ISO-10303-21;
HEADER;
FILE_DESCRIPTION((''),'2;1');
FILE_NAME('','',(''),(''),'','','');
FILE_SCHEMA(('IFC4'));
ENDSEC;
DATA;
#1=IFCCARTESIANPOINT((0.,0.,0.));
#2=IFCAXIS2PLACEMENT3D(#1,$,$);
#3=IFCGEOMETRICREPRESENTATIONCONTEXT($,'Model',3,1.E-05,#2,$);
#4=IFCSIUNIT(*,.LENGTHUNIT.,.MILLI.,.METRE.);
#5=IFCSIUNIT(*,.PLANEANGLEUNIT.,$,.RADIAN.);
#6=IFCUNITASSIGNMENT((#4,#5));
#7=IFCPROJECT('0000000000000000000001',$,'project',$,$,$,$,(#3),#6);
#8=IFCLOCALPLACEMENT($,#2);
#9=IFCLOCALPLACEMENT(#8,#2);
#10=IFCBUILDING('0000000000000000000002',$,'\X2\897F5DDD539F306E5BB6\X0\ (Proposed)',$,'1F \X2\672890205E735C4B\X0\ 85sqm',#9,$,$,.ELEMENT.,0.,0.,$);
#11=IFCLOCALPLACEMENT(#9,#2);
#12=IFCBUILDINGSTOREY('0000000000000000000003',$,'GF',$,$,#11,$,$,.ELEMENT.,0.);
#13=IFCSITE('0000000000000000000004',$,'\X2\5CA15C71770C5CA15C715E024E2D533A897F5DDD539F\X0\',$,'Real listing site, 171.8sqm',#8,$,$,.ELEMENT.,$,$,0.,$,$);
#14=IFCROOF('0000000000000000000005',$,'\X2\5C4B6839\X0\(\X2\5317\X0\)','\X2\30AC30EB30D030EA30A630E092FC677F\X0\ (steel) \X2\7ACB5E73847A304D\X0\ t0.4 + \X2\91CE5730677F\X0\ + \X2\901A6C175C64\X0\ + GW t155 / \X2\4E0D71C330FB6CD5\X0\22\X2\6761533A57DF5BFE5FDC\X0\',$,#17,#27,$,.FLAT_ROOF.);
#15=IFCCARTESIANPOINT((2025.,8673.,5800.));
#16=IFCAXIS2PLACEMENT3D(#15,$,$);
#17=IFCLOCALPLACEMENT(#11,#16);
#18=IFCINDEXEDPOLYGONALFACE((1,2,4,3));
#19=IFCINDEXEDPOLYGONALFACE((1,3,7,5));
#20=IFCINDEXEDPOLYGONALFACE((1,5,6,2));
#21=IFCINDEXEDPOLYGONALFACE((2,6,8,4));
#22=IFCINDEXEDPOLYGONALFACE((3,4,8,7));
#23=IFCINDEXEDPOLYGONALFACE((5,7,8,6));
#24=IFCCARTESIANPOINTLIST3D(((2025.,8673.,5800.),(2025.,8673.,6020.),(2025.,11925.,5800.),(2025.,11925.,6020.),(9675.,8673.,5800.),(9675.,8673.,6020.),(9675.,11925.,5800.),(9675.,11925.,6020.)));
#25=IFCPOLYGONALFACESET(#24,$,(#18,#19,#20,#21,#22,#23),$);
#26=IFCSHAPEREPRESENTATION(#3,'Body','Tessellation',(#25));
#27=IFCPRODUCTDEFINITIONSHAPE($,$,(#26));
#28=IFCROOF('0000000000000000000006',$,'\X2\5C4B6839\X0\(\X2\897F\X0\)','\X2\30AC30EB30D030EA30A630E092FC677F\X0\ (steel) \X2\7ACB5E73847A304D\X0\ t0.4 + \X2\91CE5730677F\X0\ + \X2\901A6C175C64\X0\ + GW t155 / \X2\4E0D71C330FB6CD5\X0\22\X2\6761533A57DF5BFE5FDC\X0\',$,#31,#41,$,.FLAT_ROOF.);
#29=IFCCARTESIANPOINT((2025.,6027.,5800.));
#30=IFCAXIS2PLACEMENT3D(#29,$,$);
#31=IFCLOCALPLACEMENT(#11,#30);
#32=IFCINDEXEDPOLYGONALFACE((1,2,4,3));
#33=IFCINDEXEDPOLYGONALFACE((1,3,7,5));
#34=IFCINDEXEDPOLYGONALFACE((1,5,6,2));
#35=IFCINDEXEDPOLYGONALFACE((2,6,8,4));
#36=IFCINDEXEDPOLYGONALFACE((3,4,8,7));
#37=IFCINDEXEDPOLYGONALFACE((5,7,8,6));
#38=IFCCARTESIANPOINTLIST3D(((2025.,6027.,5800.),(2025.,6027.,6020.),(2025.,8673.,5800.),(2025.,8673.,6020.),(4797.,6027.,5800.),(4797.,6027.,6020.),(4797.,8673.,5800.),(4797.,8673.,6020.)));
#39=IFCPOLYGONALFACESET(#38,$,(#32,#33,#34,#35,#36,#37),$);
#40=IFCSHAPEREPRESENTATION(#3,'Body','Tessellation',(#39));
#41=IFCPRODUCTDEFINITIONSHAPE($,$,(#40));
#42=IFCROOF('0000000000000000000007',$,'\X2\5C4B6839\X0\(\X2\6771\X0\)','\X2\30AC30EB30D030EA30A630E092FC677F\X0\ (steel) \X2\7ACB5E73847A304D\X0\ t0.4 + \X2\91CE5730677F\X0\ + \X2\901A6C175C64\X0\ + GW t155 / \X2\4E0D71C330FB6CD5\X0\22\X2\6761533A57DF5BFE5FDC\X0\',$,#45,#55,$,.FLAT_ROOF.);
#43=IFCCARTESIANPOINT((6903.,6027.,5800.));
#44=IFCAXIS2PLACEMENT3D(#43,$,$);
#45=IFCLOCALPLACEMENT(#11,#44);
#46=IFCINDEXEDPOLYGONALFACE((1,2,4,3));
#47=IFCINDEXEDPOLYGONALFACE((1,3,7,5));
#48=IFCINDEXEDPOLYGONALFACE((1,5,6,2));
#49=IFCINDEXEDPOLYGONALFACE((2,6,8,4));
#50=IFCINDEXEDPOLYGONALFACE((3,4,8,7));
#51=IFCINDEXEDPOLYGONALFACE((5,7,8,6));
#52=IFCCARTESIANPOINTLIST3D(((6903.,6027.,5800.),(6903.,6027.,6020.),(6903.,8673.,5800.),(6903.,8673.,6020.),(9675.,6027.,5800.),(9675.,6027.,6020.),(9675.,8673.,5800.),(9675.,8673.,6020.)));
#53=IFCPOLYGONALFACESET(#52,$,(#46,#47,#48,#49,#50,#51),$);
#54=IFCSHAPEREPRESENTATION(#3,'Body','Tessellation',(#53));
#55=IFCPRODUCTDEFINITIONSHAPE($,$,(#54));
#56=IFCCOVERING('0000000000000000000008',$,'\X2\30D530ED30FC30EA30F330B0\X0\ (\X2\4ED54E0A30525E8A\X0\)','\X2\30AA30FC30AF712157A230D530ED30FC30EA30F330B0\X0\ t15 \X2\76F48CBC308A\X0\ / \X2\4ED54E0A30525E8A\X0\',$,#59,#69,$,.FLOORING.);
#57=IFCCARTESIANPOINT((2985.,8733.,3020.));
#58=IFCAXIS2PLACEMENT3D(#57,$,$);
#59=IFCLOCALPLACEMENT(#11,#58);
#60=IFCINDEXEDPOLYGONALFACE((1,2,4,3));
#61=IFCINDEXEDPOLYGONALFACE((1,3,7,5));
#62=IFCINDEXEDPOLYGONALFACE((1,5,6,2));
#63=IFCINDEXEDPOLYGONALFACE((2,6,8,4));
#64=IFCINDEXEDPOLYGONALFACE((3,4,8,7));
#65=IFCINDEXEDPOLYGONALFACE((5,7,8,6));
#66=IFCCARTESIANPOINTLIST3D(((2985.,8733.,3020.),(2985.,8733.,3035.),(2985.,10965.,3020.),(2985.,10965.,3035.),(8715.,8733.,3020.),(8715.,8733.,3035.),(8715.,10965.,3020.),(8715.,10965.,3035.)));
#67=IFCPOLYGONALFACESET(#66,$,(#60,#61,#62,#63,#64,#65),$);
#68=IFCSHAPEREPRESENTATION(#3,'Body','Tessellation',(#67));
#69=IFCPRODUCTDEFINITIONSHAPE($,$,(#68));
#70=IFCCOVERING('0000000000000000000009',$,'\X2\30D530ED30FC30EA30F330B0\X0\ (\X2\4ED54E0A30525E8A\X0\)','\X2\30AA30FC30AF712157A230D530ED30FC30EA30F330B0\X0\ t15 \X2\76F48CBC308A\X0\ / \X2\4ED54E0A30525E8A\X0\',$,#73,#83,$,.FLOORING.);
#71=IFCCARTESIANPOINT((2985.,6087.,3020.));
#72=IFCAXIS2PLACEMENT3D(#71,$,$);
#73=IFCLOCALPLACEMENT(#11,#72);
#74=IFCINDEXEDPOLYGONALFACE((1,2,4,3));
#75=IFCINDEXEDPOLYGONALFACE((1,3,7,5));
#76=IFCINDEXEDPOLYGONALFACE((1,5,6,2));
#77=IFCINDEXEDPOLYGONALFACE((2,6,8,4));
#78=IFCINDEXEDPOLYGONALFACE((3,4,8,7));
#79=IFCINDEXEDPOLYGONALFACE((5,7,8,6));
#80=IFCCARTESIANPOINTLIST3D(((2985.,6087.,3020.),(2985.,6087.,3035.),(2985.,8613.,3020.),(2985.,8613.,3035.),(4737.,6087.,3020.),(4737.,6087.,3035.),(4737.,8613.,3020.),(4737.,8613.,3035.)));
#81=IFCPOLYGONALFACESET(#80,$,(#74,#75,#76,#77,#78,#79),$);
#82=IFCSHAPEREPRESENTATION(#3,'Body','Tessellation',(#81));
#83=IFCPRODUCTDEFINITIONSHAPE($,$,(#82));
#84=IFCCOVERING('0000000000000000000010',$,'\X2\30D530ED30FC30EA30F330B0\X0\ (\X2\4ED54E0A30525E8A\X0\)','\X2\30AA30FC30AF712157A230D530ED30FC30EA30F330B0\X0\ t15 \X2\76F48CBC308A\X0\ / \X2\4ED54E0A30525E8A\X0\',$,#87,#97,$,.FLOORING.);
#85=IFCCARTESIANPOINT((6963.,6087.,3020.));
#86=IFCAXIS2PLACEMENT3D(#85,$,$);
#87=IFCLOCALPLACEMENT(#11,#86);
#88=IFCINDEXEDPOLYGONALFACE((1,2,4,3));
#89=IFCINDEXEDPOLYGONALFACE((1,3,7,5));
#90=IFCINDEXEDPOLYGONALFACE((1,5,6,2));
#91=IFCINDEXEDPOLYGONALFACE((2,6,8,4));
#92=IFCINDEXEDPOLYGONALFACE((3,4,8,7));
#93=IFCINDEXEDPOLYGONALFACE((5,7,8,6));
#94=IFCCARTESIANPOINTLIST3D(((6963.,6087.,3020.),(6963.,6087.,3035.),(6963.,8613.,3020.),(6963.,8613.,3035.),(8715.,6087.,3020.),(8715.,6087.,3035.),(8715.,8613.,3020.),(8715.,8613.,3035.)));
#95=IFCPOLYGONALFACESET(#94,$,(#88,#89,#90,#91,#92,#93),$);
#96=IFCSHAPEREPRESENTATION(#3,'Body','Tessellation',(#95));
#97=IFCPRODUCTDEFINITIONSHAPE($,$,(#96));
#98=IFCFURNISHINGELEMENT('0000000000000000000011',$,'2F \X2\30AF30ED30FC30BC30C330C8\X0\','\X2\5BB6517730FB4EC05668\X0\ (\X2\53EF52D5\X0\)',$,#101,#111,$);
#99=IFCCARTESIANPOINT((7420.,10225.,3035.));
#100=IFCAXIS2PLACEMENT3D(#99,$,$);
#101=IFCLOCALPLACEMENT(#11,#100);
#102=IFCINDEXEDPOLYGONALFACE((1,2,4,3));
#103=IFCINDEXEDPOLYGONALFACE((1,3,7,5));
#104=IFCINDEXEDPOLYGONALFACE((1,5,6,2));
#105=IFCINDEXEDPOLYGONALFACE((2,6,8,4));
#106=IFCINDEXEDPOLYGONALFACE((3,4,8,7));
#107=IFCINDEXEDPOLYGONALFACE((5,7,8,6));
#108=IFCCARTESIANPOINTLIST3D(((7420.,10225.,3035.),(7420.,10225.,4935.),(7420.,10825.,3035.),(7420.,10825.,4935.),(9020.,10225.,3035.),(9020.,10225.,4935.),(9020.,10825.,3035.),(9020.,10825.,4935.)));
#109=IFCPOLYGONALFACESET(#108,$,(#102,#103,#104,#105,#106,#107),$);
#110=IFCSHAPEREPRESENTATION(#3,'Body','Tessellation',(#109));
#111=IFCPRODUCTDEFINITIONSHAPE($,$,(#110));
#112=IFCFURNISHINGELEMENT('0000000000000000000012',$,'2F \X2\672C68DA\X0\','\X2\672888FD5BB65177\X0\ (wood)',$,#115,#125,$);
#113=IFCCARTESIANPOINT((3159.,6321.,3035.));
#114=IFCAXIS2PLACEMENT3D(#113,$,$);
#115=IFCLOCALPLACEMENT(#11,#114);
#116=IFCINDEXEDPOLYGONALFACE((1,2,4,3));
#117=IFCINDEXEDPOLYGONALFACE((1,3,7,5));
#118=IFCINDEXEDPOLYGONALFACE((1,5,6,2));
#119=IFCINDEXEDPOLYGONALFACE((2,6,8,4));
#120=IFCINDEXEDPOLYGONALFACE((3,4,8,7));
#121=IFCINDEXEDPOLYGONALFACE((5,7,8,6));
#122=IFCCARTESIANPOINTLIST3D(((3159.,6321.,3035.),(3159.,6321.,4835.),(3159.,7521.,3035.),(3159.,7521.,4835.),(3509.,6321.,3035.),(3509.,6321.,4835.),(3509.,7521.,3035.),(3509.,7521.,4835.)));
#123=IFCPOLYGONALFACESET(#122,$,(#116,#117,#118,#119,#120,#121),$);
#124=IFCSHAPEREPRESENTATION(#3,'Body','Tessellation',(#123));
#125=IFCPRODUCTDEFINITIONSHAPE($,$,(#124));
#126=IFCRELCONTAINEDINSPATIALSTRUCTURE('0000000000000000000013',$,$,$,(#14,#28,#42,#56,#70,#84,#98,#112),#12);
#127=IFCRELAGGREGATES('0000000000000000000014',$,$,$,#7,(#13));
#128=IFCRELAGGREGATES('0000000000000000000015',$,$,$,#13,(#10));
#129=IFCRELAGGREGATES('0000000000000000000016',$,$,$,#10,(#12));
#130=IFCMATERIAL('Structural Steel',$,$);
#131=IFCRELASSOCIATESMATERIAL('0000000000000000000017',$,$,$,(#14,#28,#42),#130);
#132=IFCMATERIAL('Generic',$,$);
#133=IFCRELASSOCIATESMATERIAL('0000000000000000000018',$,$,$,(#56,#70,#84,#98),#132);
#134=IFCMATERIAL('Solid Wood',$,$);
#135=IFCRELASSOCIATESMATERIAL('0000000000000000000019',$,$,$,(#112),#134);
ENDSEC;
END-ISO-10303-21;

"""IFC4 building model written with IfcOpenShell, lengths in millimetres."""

from ifc_helpers import new_model, si_unit, frame, frame_2d, origin, place, context, project, spatial, rectangle, extrude, material, element, save


model = new_model("IFC4")

# Units and contexts
model_context = context("Model", 3, precision=1e-05, world=origin())
ifc_project = project(units=[si_unit("LENGTHUNIT", "METRE", prefix="MILLI"), si_unit("PLANEANGLEUNIT", "RADIAN")], contexts=[model_context])

# Site, building, storey
site_placement = place(None, origin())
site = spatial("IfcSite", under=ifc_project, at=site_placement, Name="岡山県岡山市中区西川原", ObjectType="Real listing site, 171.8sqm", CompositionType="ELEMENT", RefElevation=0.0)
building_placement = place(site_placement, origin())
building = spatial("IfcBuilding", under=site, at=building_placement, Name="西川原の家 (Proposed)", ObjectType="1F 木造平屋 85sqm", CompositionType="ELEMENT", ElevationOfRefHeight=0.0, ElevationOfTerrain=0.0)
storey_placement = place(building_placement, origin())
storey = spatial("IfcBuildingStorey", under=building, at=storey_placement, Name="GF", CompositionType="ELEMENT", Elevation=0.0)

# Shared definitions
ifc_material_1 = material(Name="Solid Wood")

# Roofs
ifc_material_2 = material(Name="Structural Steel")
for number, where, name in (
    (1, (2025.0, 8673.0, 5800.0), "屋根(北)"),
):
    element("IfcRoof", number, at=place(storey_placement, frame(where)), inside=storey, material=ifc_material_2, Name=name, Description="ガルバリウム鋼板 (steel) 立平葺き t0.4 + 野地板 + 通気層 + GW t155 / 不燃・法22条区域対応", PredefinedType="FLAT_ROOF", context=model_context, shape_type="SweptSolid", body=[
        extrude(rectangle(XDim=7650.0, YDim=3252.0, at=frame_2d((3825.0, 1626.0))), frame((2025.0, 8673.0, 5800.0)), (0.0, 0.0, 1.0), 220.0),
    ])
roof_1_placement = place(storey_placement, frame((2025.0, 6027.0, 5800.0)))
element("IfcRoof", 2, at=roof_1_placement, inside=storey, material=ifc_material_2, Name="屋根(西)", Description="ガルバリウム鋼板 (steel) 立平葺き t0.4 + 野地板 + 通気層 + GW t155 / 不燃・法22条区域対応", PredefinedType="FLAT_ROOF", context=model_context, shape_type="SweptSolid", body=[
    extrude(rectangle(XDim=2772.0, YDim=2646.0, at=frame_2d((1386.0, 1323.0))), frame((2025.0, 6027.0, 5800.0)), (0.0, 0.0, 1.0), 220.0),
])
roof_2_placement = place(storey_placement, frame((6903.0, 6027.0, 5800.0)))
element("IfcRoof", 3, at=roof_2_placement, inside=storey, material=ifc_material_2, Name="屋根(東)", Description="ガルバリウム鋼板 (steel) 立平葺き t0.4 + 野地板 + 通気層 + GW t155 / 不燃・法22条区域対応", PredefinedType="FLAT_ROOF", context=model_context, shape_type="SweptSolid", body=[
    extrude(rectangle(XDim=2772.0, YDim=2646.0, at=frame_2d((1386.0, 1323.0))), frame((6903.0, 6027.0, 5800.0)), (0.0, 0.0, 1.0), 220.0),
])

# Coverings
ifc_material_3 = material(Name="Generic")
covering_1_placement = place(storey_placement, frame((2985.0, 8733.0, 3020.0)))
element("IfcCovering", 4, at=covering_1_placement, inside=storey, material=ifc_material_3, Name="フローリング (仕上げ床)", Description="オーク無垢フローリング t15 直貼り / 仕上げ床", PredefinedType="FLOORING", context=model_context, shape_type="SweptSolid", body=[
    extrude(rectangle(XDim=5730.0, YDim=2232.0, at=frame_2d((2865.0, 1116.0))), frame((2985.0, 8733.0, 3020.0)), (0.0, 0.0, 1.0), 15.0),
])
covering_2_placement = place(storey_placement, frame((2985.0, 6087.0, 3020.0)))
element("IfcCovering", 5, at=covering_2_placement, inside=storey, material=ifc_material_3, Name="フローリング (仕上げ床)", Description="オーク無垢フローリング t15 直貼り / 仕上げ床", PredefinedType="FLOORING", context=model_context, shape_type="SweptSolid", body=[
    extrude(rectangle(XDim=1752.0, YDim=2526.0, at=frame_2d((876.0, 1263.0))), frame((2985.0, 6087.0, 3020.0)), (0.0, 0.0, 1.0), 15.0),
])
covering_3_placement = place(storey_placement, frame((6963.0, 6087.0, 3020.0)))
element("IfcCovering", 6, at=covering_3_placement, inside=storey, material=ifc_material_3, Name="フローリング (仕上げ床)", Description="オーク無垢フローリング t15 直貼り / 仕上げ床", PredefinedType="FLOORING", context=model_context, shape_type="SweptSolid", body=[
    extrude(rectangle(XDim=1752.0, YDim=2526.0, at=frame_2d((876.0, 1263.0))), frame((6963.0, 6087.0, 3020.0)), (0.0, 0.0, 1.0), 15.0),
])

# Furnishing elements
furnishing_1_placement = place(storey_placement, frame((7420.0, 10225.0, 3035.0)))
element("IfcFurnishingElement", 7, at=furnishing_1_placement, inside=storey, material=ifc_material_3, Name="2F クローゼット", Description="家具・什器 (可動)", context=model_context, shape_type="SweptSolid", body=[
    extrude(rectangle(XDim=1600.0, YDim=600.0, at=frame_2d((800.0, 300.0))), frame((7420.0, 10225.0, 3035.0)), (0.0, 0.0, 1.0), 1900.0),
])
furnishing_2_placement = place(storey_placement, frame((3159.0, 6321.0, 3035.0)))
element("IfcFurnishingElement", 8, at=furnishing_2_placement, inside=storey, material=ifc_material_1, Name="2F 本棚", Description="木製家具 (wood)", context=model_context, shape_type="SweptSolid", body=[
    extrude(rectangle(XDim=350.0, YDim=1200.0, at=frame_2d((175.0, 600.0))), frame((3159.0, 6321.0, 3035.0)), (0.0, 0.0, 1.0), 1800.0),
])

save(model, "model.ifc")
